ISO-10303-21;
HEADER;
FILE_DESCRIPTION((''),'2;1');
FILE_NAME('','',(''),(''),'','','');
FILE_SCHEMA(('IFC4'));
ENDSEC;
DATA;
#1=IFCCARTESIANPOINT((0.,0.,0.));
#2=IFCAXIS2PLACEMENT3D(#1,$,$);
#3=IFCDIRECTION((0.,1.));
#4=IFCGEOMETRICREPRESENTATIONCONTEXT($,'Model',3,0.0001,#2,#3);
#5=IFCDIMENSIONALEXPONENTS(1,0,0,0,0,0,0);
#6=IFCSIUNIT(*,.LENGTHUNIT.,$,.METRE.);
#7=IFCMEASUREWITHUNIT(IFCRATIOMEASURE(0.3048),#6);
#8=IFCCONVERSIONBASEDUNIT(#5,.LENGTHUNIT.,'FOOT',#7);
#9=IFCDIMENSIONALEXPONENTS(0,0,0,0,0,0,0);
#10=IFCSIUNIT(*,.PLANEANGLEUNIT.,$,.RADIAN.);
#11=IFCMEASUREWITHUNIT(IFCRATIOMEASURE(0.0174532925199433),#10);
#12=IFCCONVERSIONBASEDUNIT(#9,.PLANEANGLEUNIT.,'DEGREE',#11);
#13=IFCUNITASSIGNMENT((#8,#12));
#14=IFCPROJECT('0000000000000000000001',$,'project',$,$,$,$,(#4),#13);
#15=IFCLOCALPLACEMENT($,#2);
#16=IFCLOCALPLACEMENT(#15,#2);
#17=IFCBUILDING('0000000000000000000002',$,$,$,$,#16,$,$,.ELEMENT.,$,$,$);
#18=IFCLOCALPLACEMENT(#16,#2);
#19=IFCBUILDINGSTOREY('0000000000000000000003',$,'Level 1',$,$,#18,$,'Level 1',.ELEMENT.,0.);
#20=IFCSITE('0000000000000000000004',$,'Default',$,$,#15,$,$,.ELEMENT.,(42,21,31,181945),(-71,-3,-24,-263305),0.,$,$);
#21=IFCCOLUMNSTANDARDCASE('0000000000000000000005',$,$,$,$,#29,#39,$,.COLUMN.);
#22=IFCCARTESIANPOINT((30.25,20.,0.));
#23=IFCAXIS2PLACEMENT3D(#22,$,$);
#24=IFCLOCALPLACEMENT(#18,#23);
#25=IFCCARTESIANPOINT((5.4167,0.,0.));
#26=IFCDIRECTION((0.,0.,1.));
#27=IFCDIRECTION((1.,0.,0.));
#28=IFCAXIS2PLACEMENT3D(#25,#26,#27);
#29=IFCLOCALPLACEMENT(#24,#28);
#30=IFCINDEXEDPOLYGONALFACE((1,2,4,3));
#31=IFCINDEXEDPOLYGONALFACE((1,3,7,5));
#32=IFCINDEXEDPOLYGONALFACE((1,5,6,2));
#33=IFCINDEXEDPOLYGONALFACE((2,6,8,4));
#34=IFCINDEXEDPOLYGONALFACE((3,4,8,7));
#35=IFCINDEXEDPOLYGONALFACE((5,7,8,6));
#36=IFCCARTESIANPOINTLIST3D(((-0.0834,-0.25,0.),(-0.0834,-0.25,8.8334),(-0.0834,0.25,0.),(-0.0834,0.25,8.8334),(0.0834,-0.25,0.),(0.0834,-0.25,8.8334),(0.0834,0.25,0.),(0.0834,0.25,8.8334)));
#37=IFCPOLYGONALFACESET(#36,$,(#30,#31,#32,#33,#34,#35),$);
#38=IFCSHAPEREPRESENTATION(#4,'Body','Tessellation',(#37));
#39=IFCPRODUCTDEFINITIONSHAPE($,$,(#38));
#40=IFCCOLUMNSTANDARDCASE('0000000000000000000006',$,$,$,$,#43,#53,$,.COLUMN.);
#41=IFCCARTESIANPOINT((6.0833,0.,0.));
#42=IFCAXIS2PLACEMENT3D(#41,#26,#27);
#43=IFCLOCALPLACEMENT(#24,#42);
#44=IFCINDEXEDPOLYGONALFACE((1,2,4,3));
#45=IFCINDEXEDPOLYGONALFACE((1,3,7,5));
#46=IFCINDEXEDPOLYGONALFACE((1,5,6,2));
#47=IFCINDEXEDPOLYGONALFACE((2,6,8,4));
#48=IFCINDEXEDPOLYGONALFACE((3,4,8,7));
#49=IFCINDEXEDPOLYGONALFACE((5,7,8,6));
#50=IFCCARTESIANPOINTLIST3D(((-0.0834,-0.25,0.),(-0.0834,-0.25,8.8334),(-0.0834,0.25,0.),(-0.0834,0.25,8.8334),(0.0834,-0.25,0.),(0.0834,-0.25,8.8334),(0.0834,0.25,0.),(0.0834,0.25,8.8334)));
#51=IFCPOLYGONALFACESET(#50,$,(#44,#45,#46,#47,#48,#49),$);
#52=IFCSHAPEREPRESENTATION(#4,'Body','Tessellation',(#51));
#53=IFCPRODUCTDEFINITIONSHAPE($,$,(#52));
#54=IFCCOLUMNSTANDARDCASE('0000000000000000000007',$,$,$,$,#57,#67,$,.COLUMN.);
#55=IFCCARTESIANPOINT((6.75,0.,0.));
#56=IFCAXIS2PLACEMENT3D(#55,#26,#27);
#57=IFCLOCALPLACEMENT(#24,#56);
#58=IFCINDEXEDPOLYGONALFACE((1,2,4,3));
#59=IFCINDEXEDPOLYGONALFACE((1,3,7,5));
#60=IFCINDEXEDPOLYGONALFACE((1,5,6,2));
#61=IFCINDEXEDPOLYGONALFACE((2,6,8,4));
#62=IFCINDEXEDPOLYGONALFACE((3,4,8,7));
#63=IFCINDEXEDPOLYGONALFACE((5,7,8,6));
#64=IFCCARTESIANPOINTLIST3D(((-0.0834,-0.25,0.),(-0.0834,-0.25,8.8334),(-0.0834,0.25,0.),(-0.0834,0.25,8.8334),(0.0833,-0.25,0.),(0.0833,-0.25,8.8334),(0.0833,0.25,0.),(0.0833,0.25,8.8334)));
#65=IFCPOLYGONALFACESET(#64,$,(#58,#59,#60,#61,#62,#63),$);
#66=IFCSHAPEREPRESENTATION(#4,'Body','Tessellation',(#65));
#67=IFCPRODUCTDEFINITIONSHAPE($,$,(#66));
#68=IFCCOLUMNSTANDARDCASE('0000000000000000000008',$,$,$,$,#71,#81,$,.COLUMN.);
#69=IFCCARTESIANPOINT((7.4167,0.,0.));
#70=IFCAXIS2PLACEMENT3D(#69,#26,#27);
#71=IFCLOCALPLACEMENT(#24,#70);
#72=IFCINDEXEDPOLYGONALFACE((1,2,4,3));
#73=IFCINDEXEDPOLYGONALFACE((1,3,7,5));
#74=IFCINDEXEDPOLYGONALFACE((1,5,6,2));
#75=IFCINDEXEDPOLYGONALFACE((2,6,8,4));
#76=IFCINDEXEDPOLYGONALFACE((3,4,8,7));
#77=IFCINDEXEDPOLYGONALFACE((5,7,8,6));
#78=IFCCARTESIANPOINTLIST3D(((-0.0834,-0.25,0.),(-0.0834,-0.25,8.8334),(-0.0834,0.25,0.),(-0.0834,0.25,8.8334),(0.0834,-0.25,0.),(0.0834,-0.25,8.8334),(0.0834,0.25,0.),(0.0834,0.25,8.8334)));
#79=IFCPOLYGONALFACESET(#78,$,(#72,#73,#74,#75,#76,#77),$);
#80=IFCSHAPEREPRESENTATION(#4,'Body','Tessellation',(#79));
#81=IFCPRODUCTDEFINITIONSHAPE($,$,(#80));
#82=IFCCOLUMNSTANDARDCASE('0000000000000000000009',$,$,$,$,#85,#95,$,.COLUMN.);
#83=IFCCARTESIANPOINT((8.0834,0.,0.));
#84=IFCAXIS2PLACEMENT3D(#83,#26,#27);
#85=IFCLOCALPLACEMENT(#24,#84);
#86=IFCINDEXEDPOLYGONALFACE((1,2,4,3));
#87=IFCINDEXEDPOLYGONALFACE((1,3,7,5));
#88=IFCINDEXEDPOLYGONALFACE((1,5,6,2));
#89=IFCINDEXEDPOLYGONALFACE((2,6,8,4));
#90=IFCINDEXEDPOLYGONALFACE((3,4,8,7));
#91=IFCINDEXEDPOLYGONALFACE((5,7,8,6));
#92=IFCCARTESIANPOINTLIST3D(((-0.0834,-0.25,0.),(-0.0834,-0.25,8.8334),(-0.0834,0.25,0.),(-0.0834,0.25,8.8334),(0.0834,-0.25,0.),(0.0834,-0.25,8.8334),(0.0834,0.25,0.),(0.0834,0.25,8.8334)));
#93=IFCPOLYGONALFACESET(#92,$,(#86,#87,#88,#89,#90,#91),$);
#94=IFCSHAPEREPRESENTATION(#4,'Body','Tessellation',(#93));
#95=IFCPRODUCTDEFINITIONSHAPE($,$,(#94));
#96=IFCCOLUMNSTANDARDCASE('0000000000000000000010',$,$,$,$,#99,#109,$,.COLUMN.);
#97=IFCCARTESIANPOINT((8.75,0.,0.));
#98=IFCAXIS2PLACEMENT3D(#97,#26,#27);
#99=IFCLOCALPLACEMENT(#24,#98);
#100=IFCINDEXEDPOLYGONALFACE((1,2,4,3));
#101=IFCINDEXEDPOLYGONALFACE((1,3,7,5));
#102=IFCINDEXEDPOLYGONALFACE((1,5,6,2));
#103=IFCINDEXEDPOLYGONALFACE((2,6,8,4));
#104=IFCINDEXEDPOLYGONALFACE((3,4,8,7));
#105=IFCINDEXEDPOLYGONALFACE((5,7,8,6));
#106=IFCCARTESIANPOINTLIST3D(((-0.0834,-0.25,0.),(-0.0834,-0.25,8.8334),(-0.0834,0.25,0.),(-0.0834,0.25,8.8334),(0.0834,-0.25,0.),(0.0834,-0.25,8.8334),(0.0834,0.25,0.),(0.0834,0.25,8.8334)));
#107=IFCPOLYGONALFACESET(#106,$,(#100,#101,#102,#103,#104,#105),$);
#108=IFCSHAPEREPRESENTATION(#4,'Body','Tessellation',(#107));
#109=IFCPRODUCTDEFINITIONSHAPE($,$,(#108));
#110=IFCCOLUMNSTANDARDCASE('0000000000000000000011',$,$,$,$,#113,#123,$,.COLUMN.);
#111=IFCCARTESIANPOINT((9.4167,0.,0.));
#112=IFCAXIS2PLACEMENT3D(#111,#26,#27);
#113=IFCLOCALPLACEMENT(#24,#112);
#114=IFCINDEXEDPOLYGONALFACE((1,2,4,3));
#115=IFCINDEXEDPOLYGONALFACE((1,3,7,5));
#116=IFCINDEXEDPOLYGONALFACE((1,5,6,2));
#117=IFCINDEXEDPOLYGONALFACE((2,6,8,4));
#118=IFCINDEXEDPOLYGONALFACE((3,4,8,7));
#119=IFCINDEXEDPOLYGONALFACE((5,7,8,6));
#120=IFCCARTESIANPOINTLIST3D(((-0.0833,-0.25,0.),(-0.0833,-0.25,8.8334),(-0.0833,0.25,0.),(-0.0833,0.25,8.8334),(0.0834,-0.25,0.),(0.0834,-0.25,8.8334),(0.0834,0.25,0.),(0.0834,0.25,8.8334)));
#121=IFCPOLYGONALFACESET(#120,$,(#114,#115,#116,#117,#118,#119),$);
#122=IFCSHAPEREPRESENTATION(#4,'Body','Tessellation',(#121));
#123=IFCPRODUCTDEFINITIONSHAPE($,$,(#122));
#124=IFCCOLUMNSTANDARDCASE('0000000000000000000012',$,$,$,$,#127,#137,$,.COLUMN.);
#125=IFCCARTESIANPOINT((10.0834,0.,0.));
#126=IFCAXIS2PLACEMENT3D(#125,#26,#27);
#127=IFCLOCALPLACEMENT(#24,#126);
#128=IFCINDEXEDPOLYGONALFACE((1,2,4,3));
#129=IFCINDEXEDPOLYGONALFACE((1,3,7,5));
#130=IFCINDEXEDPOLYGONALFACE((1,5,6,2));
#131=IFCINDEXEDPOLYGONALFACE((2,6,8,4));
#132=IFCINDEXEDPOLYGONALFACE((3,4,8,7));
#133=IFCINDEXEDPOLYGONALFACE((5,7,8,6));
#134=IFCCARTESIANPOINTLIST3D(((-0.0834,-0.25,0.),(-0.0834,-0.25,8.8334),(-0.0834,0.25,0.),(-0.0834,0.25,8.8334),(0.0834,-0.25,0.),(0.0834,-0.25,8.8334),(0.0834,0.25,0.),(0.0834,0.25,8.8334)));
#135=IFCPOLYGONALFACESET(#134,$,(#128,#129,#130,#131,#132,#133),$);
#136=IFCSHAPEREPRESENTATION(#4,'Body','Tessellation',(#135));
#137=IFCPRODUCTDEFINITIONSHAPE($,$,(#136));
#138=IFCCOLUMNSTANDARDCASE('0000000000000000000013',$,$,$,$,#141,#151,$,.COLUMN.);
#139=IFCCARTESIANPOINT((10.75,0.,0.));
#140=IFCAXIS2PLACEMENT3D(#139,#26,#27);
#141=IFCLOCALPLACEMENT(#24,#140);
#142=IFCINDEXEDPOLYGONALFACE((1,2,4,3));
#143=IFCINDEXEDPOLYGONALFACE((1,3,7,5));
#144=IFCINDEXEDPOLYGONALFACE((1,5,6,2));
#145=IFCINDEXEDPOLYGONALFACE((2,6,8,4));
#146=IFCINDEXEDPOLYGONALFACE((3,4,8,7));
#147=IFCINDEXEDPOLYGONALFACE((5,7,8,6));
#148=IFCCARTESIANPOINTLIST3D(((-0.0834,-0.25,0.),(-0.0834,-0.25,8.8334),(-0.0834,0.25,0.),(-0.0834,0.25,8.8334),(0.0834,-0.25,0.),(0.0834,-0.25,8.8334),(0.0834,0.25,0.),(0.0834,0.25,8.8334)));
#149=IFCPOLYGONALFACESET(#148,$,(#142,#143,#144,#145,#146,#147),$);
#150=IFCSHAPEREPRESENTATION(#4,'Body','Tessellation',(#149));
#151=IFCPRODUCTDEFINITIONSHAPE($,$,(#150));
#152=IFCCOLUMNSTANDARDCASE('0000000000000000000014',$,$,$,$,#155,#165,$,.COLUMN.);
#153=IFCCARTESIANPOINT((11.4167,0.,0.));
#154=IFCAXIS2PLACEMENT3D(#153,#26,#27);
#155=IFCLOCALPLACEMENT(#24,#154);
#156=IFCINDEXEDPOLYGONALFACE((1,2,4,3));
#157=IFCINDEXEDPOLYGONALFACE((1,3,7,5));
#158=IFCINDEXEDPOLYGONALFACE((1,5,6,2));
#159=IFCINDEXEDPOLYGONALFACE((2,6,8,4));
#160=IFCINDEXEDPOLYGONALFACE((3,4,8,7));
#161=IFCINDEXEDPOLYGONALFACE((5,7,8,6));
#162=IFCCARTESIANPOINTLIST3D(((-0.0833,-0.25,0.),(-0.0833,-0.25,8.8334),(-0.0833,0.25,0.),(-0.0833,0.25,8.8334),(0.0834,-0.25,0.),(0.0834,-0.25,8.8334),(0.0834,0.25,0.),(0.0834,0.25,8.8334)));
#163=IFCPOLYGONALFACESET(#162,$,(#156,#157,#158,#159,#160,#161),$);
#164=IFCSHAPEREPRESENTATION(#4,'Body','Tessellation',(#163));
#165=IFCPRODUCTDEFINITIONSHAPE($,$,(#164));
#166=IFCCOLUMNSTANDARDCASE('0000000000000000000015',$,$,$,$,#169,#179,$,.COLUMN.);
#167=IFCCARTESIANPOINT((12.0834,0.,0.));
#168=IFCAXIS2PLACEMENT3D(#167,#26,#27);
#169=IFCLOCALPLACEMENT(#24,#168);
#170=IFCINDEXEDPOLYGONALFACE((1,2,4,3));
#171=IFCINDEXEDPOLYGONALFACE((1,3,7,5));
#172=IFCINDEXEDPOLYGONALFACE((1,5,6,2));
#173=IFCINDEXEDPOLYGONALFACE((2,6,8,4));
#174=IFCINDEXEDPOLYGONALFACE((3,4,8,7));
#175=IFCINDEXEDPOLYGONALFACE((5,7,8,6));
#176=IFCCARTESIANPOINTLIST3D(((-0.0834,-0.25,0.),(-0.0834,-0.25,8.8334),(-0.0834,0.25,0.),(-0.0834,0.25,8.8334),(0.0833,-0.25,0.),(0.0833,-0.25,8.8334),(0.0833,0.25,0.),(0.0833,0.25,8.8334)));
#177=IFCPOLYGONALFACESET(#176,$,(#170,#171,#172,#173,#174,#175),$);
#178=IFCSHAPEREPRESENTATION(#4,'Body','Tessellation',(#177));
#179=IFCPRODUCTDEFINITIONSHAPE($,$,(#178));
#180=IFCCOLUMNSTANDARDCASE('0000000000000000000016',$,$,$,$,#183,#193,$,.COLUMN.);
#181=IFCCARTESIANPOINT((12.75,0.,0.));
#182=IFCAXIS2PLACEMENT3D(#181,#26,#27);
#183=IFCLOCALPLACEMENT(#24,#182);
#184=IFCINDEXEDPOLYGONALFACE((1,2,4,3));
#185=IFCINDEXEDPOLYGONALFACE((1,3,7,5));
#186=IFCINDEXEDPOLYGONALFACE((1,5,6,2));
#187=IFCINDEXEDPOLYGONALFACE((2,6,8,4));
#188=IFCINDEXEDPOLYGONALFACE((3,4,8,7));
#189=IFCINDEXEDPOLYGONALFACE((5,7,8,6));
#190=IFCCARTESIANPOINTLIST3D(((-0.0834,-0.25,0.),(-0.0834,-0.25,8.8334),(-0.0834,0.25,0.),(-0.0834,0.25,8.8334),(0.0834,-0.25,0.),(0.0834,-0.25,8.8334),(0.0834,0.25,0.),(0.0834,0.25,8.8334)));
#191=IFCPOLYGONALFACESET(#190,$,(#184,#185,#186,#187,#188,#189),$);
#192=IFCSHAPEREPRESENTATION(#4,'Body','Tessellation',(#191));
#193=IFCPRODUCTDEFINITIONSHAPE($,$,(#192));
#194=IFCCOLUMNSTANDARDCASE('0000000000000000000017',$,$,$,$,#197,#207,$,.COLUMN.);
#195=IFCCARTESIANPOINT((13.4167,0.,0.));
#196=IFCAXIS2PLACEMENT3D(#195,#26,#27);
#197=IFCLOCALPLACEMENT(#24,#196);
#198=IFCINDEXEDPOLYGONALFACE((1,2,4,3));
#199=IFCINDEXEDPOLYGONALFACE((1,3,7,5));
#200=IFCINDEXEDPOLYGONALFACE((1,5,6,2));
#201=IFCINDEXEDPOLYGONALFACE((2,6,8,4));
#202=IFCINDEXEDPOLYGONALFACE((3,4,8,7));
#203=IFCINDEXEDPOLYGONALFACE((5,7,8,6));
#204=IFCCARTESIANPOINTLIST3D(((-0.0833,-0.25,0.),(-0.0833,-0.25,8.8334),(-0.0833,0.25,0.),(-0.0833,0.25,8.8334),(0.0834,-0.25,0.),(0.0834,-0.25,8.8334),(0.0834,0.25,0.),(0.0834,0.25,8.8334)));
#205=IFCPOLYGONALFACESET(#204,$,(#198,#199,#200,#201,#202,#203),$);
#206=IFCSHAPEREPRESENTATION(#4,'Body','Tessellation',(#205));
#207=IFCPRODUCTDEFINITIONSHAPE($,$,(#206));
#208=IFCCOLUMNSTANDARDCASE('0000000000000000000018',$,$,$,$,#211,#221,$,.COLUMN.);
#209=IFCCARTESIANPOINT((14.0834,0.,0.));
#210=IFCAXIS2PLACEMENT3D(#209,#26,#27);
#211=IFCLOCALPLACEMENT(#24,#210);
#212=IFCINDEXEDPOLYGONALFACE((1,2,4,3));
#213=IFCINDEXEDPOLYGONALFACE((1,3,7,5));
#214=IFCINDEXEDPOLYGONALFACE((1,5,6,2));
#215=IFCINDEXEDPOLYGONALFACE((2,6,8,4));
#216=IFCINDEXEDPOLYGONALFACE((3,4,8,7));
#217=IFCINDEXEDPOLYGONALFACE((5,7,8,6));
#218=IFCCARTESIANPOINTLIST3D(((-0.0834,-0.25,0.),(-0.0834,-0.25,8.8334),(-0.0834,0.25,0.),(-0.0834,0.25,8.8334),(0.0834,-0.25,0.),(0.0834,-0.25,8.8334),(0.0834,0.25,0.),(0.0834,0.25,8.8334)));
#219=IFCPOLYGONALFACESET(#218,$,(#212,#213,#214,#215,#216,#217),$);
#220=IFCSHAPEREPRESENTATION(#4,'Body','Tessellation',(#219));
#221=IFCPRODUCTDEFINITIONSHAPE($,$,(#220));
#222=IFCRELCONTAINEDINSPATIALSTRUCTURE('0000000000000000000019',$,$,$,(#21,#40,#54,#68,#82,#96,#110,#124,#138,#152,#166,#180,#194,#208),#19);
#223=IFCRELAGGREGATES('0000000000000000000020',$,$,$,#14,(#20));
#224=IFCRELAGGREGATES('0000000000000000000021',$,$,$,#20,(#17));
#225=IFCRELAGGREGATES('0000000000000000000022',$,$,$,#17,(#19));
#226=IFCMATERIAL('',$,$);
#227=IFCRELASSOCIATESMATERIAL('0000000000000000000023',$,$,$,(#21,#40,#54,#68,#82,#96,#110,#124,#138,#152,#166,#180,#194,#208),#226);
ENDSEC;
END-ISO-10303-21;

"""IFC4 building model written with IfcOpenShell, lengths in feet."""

from ifc_helpers import new_model, entity, si_unit, converted_unit, direction, frame, origin, place, context, project, spatial, rectangle, extrude, material, element, save


model = new_model("IFC4")

# Units and contexts
model_context = context("Model", 3, precision=0.0001, world=origin(), true_north=direction((0.0, 1.0)))
ifc_project = project(units=[converted_unit("LENGTHUNIT", "FOOT", entity("IfcRatioMeasure", 0.3048), si_unit("LENGTHUNIT", "METRE"), dimensions=[1, 0, 0, 0, 0, 0, 0]), converted_unit("PLANEANGLEUNIT", "DEGREE", entity("IfcRatioMeasure", 0.0174532925199433), si_unit("PLANEANGLEUNIT", "RADIAN"), dimensions=[0, 0, 0, 0, 0, 0, 0])], contexts=[model_context])

# Site, building, storey
site_placement = place(None, origin())
site = spatial("IfcSite", under=ifc_project, at=site_placement, Name="Default", CompositionType="ELEMENT", RefLatitude=(42, 21, 31, 181945), RefLongitude=(-71, -3, -24, -263305), RefElevation=0.0)
building_placement = place(site_placement, origin())
building = spatial("IfcBuilding", under=site, at=building_placement, CompositionType="ELEMENT")
storey_placement = place(building_placement, origin())
storey = spatial("IfcBuildingStorey", under=building, at=storey_placement, Name="Level 1", LongName="Level 1", CompositionType="ELEMENT", Elevation=0.0)

# Columns
ifc_material_1 = material(Name="")
placement = place(storey_placement, frame((30.25, 20.0, 0.0)))
for number, where, z_axis, x_axis in (
    (1, (5.4167, 0.0, 0.0), (0.0, 0.0, 1.0), (1.0, 0.0, 0.0)),
    (2, (6.0833, 0.0, 0.0), (0.0, 0.0, 1.0), (1.0, 0.0, 0.0)),
    (3, (6.75, 0.0, 0.0), (0.0, 0.0, 1.0), (1.0, 0.0, 0.0)),
    (4, (7.4167, 0.0, 0.0), (0.0, 0.0, 1.0), (1.0, 0.0, 0.0)),
    (5, (8.0834, 0.0, 0.0), (0.0, 0.0, 1.0), (1.0, 0.0, 0.0)),
    (6, (8.75, 0.0, 0.0), (0.0, 0.0, 1.0), (1.0, 0.0, 0.0)),
    (7, (9.4167, 0.0, 0.0), (0.0, 0.0, 1.0), (1.0, 0.0, 0.0)),
    (8, (10.0834, 0.0, 0.0), (0.0, 0.0, 1.0), (1.0, 0.0, 0.0)),
    (9, (10.75, 0.0, 0.0), (0.0, 0.0, 1.0), (1.0, 0.0, 0.0)),
    (10, (11.4167, 0.0, 0.0), (0.0, 0.0, 1.0), (1.0, 0.0, 0.0)),
    (11, (12.0834, 0.0, 0.0), (0.0, 0.0, 1.0), (1.0, 0.0, 0.0)),
    (12, (12.75, 0.0, 0.0), (0.0, 0.0, 1.0), (1.0, 0.0, 0.0)),
    (13, (13.4167, 0.0, 0.0), (0.0, 0.0, 1.0), (1.0, 0.0, 0.0)),
    (14, (14.0834, 0.0, 0.0), (0.0, 0.0, 1.0), (1.0, 0.0, 0.0)),
):
    element("IfcColumnStandardCase", number, at=place(placement, frame(where, z_axis=z_axis, x_axis=x_axis)), inside=storey, material=ifc_material_1, PredefinedType="COLUMN", context=model_context, shape_type="SweptSolid", body=[
        extrude(rectangle(XDim=0.1667, YDim=0.5), origin(), (0.0, 0.0, 1.0), 8.8334),
    ])

save(model, "model.ifc")
